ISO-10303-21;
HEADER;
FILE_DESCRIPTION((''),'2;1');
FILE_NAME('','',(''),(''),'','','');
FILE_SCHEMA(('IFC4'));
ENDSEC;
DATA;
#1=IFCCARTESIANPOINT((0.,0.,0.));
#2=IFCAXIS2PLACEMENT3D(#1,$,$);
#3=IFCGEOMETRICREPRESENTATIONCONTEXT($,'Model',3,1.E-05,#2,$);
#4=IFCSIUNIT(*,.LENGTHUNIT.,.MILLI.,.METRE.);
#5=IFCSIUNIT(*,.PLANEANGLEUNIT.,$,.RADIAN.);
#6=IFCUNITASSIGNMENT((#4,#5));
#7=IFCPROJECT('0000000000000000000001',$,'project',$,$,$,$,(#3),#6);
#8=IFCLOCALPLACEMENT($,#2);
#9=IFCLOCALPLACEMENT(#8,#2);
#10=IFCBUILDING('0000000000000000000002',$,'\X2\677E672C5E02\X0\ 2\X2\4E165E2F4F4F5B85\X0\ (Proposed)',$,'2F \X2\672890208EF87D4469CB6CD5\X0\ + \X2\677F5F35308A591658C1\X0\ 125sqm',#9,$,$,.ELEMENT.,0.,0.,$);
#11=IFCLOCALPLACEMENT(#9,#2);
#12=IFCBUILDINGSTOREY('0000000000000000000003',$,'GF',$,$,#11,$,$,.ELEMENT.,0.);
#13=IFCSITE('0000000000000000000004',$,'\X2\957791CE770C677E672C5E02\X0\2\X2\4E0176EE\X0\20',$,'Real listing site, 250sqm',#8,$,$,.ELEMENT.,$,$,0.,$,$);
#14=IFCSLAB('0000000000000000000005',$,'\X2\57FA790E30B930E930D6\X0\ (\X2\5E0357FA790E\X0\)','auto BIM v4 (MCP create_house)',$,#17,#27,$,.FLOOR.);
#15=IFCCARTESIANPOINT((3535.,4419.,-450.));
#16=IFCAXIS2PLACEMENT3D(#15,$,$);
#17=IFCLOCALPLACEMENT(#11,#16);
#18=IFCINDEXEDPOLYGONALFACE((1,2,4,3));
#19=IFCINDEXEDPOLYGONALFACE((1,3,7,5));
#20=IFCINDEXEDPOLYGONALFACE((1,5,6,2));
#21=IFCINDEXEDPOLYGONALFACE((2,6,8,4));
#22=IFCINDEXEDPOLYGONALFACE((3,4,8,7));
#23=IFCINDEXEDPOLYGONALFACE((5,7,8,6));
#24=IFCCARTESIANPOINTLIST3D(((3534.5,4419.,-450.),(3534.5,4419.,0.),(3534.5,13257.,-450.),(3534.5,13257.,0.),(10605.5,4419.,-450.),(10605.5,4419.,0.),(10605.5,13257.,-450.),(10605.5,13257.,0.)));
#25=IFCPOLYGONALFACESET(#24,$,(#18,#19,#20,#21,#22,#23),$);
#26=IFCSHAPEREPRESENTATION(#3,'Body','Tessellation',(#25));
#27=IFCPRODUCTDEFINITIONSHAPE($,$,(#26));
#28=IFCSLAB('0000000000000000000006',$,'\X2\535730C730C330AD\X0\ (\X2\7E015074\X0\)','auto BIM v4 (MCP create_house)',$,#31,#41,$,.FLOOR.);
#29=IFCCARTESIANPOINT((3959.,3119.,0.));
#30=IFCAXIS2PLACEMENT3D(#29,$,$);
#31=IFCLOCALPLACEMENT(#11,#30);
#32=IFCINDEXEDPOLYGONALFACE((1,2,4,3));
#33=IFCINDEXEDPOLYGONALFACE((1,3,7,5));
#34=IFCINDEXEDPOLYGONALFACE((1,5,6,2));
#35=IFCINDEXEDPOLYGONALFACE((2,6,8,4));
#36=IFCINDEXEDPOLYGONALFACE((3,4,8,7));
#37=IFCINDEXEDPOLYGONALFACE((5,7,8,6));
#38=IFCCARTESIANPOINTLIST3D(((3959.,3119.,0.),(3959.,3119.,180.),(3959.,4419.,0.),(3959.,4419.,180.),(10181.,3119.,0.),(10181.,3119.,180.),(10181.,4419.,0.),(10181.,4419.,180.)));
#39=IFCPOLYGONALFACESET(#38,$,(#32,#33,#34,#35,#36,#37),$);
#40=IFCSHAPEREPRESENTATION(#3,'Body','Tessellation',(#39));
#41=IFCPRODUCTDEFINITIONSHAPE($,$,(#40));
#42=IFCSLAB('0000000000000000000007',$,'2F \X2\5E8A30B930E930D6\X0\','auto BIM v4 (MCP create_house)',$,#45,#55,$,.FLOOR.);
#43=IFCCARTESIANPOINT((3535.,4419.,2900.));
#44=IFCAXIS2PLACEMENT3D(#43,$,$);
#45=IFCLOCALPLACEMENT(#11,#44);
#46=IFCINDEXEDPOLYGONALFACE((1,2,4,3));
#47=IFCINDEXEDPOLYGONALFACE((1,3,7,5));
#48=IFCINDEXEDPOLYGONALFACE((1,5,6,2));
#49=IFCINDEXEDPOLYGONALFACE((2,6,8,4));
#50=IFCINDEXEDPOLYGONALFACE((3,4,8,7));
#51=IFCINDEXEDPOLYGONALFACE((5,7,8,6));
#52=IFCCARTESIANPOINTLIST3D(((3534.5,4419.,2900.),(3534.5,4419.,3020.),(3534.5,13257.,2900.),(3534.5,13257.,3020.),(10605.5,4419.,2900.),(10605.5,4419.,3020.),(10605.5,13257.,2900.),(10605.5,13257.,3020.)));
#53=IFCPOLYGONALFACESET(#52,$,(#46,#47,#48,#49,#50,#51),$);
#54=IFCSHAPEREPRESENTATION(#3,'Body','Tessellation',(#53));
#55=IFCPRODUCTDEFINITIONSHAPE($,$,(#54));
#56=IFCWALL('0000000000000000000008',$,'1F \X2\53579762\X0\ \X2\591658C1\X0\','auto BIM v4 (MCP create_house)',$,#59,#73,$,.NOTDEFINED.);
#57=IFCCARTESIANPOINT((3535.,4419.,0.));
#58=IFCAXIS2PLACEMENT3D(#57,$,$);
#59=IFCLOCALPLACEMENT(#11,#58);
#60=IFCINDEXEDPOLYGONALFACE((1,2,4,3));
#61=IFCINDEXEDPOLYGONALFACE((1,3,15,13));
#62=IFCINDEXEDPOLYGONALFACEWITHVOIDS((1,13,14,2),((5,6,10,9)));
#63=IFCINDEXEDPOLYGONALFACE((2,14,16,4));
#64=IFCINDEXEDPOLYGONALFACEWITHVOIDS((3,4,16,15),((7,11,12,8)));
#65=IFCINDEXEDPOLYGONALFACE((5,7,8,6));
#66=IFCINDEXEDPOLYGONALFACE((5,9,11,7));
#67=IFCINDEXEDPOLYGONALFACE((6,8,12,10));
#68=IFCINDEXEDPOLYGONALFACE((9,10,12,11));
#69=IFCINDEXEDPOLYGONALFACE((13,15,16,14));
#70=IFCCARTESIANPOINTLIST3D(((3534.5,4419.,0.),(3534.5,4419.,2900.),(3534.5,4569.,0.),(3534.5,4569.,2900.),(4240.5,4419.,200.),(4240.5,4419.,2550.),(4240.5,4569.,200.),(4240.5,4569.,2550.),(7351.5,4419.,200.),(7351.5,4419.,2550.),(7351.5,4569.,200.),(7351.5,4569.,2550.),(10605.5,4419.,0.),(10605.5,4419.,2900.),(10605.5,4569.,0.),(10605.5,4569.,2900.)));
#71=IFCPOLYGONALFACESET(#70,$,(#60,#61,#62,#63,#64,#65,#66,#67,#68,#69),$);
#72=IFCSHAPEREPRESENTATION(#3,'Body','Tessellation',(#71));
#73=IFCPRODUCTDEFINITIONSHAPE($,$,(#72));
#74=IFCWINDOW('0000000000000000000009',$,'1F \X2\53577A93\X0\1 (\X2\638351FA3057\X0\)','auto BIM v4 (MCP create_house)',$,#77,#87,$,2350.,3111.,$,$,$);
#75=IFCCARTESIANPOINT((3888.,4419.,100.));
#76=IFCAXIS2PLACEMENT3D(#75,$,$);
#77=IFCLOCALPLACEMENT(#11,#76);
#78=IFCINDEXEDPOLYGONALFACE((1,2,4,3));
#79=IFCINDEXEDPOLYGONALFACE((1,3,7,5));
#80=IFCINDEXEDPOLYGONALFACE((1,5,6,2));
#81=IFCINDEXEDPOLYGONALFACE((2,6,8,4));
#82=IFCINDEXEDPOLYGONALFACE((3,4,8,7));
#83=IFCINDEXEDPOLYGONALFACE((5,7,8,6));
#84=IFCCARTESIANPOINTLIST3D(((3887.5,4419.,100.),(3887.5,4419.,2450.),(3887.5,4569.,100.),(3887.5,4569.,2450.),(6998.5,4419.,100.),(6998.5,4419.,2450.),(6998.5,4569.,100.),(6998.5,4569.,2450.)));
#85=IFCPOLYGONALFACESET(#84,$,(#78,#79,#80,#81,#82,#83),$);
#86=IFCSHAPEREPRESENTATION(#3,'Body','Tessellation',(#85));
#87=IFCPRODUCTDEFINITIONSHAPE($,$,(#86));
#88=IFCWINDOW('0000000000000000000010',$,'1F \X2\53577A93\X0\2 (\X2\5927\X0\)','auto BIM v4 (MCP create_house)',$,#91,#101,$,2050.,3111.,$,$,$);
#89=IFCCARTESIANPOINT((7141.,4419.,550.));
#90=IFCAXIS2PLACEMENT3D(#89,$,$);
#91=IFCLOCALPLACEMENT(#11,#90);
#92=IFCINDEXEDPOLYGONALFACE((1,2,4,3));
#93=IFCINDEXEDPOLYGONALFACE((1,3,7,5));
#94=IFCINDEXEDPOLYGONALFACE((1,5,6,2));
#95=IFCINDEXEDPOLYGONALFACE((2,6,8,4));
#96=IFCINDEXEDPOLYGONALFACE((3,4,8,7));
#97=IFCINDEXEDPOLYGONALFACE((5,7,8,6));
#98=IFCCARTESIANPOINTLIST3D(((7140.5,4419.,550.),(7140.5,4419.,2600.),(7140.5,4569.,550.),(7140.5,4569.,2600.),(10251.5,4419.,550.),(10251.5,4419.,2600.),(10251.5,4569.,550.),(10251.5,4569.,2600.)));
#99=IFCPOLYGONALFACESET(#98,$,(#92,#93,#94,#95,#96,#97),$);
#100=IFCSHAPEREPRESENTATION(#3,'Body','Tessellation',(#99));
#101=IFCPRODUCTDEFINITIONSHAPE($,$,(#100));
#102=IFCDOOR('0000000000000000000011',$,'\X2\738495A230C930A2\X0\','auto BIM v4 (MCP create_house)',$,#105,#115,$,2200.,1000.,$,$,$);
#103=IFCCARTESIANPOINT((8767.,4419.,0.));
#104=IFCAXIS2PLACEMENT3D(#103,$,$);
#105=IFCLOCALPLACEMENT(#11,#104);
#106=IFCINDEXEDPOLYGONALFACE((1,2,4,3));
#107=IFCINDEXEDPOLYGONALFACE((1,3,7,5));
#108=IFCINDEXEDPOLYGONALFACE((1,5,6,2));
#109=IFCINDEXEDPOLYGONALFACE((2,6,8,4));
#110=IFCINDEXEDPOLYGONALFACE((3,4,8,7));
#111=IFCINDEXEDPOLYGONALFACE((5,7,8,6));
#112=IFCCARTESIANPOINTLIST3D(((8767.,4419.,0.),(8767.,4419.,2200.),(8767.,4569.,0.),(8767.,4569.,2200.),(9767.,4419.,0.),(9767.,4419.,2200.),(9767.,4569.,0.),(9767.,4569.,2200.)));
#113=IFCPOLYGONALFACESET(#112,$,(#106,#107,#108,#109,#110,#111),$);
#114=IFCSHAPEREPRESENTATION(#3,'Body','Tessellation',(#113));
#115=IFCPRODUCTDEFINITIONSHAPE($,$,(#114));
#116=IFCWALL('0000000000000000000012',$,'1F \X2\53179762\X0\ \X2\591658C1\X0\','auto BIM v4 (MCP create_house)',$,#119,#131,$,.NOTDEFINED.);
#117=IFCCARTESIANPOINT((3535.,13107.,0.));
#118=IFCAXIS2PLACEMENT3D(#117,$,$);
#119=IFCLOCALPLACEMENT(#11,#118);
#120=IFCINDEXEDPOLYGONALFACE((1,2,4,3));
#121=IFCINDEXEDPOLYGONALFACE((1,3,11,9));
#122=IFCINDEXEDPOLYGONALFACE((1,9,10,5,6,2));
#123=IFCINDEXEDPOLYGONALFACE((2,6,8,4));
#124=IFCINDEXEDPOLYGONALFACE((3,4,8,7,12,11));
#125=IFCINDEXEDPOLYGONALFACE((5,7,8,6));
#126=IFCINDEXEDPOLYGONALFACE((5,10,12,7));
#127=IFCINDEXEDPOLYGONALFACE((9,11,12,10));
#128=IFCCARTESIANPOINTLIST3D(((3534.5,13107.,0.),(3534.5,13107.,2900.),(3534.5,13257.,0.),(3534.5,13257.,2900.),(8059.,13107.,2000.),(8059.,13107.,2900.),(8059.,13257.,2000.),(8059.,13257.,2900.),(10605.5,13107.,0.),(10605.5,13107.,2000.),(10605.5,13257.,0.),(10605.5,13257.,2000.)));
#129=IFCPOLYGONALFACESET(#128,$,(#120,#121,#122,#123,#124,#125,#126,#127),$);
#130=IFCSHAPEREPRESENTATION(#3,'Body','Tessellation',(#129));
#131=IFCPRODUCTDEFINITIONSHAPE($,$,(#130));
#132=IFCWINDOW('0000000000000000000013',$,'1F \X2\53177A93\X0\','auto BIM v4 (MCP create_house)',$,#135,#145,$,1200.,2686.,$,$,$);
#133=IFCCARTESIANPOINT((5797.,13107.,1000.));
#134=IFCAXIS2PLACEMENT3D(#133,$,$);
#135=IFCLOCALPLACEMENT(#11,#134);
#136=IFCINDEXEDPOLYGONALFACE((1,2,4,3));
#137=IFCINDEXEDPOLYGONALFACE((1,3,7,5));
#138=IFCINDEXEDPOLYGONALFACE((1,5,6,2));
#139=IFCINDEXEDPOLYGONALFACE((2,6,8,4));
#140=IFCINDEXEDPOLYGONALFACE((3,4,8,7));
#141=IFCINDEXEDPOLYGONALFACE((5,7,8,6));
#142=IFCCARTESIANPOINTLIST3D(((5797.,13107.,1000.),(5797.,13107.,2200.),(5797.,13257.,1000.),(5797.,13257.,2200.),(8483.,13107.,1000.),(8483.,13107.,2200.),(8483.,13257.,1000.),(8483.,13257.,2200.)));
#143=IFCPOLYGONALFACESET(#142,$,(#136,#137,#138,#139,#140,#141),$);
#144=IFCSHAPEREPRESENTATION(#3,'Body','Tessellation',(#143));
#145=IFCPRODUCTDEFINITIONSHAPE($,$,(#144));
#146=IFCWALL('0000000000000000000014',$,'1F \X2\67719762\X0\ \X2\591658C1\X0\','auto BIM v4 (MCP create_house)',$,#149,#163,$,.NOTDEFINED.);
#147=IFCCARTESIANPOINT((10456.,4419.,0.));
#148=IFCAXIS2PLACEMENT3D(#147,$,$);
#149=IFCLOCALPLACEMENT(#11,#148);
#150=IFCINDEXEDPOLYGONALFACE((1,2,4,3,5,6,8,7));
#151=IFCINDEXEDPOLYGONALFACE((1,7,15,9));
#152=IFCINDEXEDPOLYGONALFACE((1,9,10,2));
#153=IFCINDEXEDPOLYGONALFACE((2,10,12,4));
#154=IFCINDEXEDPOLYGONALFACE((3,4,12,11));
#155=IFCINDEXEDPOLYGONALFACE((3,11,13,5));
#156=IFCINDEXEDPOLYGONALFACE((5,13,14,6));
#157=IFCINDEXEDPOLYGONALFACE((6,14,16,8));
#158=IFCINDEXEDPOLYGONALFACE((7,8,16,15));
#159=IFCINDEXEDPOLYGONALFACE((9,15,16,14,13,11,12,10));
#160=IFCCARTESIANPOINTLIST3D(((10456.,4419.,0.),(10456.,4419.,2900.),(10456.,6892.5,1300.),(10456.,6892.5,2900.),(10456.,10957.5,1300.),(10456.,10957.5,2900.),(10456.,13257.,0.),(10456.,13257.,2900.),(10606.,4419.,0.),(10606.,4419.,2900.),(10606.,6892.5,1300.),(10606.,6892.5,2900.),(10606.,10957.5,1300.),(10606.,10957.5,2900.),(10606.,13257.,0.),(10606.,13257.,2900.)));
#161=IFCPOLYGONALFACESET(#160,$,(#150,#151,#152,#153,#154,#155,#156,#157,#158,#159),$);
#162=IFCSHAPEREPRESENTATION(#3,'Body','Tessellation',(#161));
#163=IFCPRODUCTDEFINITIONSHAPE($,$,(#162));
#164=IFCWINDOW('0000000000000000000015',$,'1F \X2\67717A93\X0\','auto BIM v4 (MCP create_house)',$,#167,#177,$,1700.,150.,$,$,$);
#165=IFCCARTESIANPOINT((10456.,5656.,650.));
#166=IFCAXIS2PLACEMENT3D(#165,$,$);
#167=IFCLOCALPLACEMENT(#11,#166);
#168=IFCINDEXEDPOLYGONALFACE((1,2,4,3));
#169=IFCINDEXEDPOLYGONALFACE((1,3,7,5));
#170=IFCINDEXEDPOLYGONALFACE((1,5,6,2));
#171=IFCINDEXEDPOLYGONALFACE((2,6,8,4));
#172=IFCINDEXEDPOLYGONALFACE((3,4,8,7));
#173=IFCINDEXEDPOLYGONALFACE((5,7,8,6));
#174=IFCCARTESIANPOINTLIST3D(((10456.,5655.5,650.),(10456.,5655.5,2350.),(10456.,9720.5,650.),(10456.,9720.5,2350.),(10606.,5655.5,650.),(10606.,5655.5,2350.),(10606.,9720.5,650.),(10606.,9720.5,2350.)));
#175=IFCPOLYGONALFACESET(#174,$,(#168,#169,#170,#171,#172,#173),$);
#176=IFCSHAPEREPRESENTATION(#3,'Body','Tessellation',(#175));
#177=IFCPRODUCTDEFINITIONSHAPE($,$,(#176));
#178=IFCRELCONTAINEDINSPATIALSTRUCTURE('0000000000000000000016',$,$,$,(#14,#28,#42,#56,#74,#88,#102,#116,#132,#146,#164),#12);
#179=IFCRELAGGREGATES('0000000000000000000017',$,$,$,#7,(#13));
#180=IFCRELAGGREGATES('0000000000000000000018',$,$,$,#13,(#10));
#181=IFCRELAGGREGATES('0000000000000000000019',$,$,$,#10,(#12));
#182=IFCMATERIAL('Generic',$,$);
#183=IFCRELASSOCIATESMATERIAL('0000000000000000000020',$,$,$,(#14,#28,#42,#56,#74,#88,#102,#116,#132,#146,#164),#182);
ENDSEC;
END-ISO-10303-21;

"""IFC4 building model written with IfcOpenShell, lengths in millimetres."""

from ifc_helpers import new_model, si_unit, frame, frame_2d, origin, place, context, project, spatial, rectangle, extrude, material, element, fill, save


model = new_model("IFC4")

# Units and contexts
model_context = context("Model", 3, precision=1e-05, world=origin())
ifc_project = project(units=[si_unit("LENGTHUNIT", "METRE", prefix="MILLI"), si_unit("PLANEANGLEUNIT", "RADIAN")], contexts=[model_context])

# Site, building, storey
site_placement = place(None, origin())
site = spatial("IfcSite", under=ifc_project, at=site_placement, Name="長野県松本市2丁目20", ObjectType="Real listing site, 250sqm", CompositionType="ELEMENT", RefElevation=0.0)
building_placement = place(site_placement, origin())
building = spatial("IfcBuilding", under=site, at=building_placement, Name="松本市 2世帯住宅 (Proposed)", ObjectType="2F 木造軸組構法 + 板張り外壁 125sqm", CompositionType="ELEMENT", ElevationOfRefHeight=0.0, ElevationOfTerrain=0.0)
storey_placement = place(building_placement, origin())
storey = spatial("IfcBuildingStorey", under=building, at=storey_placement, Name="GF", CompositionType="ELEMENT", Elevation=0.0)

# Slabs
ifc_material = material(Name="Generic")
slab_1_placement = place(storey_placement, frame((3535.0, 4419.0, -450.0)))
element("IfcSlab", 1, at=slab_1_placement, inside=storey, material=ifc_material, Name="基礎スラブ (布基礎)", Description="auto BIM v4 (MCP create_house)", PredefinedType="FLOOR", context=model_context, shape_type="SweptSolid", body=[
    extrude(rectangle(XDim=7071.0, YDim=8838.0, at=frame_2d((3535.0, 4419.0))), frame((3535.0, 4419.0, -450.0)), (0.0, 0.0, 1.0), 450.0),
])
slab_2_placement = place(storey_placement, frame((3959.0, 3119.0, 0.0)))
element("IfcSlab", 2, at=slab_2_placement, inside=storey, material=ifc_material, Name="南デッキ (縁側)", Description="auto BIM v4 (MCP create_house)", PredefinedType="FLOOR", context=model_context, shape_type="SweptSolid", body=[
    extrude(rectangle(XDim=6222.0, YDim=1300.0, at=frame_2d((3111.0, 650.0))), frame((3959.0, 3119.0, 0.0)), (0.0, 0.0, 1.0), 180.0),
])
slab_3_placement = place(storey_placement, frame((3535.0, 4419.0, 2900.0)))
element("IfcSlab", 3, at=slab_3_placement, inside=storey, material=ifc_material, Name="2F 床スラブ", Description="auto BIM v4 (MCP create_house)", PredefinedType="FLOOR", context=model_context, shape_type="SweptSolid", body=[
    extrude(rectangle(XDim=7071.0, YDim=8838.0, at=frame_2d((3535.0, 4419.0))), frame((3535.0, 4419.0, 2900.0)), (0.0, 0.0, 1.0), 120.0),
])

# Wall, openings, windows, door
wall_1_placement = place(storey_placement, frame((3535.0, 4419.0, 0.0)))
wall_1 = element("IfcWall", 4, at=wall_1_placement, inside=storey, material=ifc_material, Name="1F 南面 外壁", Description="auto BIM v4 (MCP create_house)", PredefinedType="NOTDEFINED", context=model_context, shape_type="SweptSolid", body=[
    extrude(rectangle(XDim=7071.0, YDim=150.0, at=frame_2d((3535.0, 75.0))), frame((3535.0, 4419.0, 0.0)), (0.0, 0.0, 1.0), 2900.0),
])
opening_1_placement = place(storey_placement, frame((3888.0, 4419.0, 100.0)))
opening_1 = element("IfcOpeningElement", 5, at=opening_1_placement, cuts=wall_1, PredefinedType="NOTDEFINED", context=model_context, shape_type="SweptSolid", body=[
    extrude(rectangle(XDim=3111.0, YDim=150.0, at=frame_2d((1555.0, 75.0))), frame((3888.0, 4419.0, 100.0)), (0.0, 0.0, 1.0), 2350.0),
])
opening_2_placement = place(storey_placement, frame((7141.0, 4419.0, 550.0)))
opening_2 = element("IfcOpeningElement", 6, at=opening_2_placement, cuts=wall_1, PredefinedType="NOTDEFINED", context=model_context, shape_type="SweptSolid", body=[
    extrude(rectangle(XDim=3111.0, YDim=150.0, at=frame_2d((1555.0, 75.0))), frame((7141.0, 4419.0, 550.0)), (0.0, 0.0, 1.0), 2050.0),
])
opening_3_placement = place(storey_placement, frame((8767.0, 4419.0, 0.0)))
opening_3 = element("IfcOpeningElement", 7, at=opening_3_placement, cuts=wall_1, PredefinedType="NOTDEFINED", context=model_context, shape_type="SweptSolid", body=[
    extrude(rectangle(XDim=1000.0, YDim=150.0, at=frame_2d((500.0, 75.0))), frame((8767.0, 4419.0, 0.0)), (0.0, 0.0, 1.0), 2200.0),
])
window_1_placement = place(storey_placement, frame((3888.0, 4419.0, 100.0)))
window_1 = element("IfcWindow", 8, at=window_1_placement, inside=storey, material=ifc_material, Name="1F 南窓1 (掃出し)", Description="auto BIM v4 (MCP create_house)", OverallHeight=2350.0, OverallWidth=3111.0, context=model_context, shape_type="SweptSolid", body=[
    extrude(rectangle(XDim=3111.0, YDim=150.0, at=frame_2d((1555.0, 75.0))), frame((3888.0, 4419.0, 100.0)), (0.0, 0.0, 1.0), 2350.0),
])
fill(opening_1, window_1)
window_2_placement = place(storey_placement, frame((7141.0, 4419.0, 550.0)))
window_2 = element("IfcWindow", 9, at=window_2_placement, inside=storey, material=ifc_material, Name="1F 南窓2 (大)", Description="auto BIM v4 (MCP create_house)", OverallHeight=2050.0, OverallWidth=3111.0, context=model_context, shape_type="SweptSolid", body=[
    extrude(rectangle(XDim=3111.0, YDim=150.0, at=frame_2d((1555.0, 75.0))), frame((7141.0, 4419.0, 550.0)), (0.0, 0.0, 1.0), 2050.0),
])
fill(opening_2, window_2)
door_1_placement = place(storey_placement, frame((8767.0, 4419.0, 0.0)))
door_1 = element("IfcDoor", 10, at=door_1_placement, inside=storey, material=ifc_material, Name="玄関ドア", Description="auto BIM v4 (MCP create_house)", OverallHeight=2200.0, OverallWidth=1000.0, context=model_context, shape_type="SweptSolid", body=[
    extrude(rectangle(XDim=1000.0, YDim=150.0, at=frame_2d((500.0, 75.0))), frame((8767.0, 4419.0, 0.0)), (0.0, 0.0, 1.0), 2200.0),
])
fill(opening_3, door_1)

# Walls, openings, windows
wall_2_placement = place(storey_placement, frame((3535.0, 13107.0, 0.0)))
wall_2 = element("IfcWall", 11, at=wall_2_placement, inside=storey, material=ifc_material, Name="1F 北面 外壁", Description="auto BIM v4 (MCP create_house)", PredefinedType="NOTDEFINED", context=model_context, shape_type="SweptSolid", body=[
    extrude(rectangle(XDim=7071.0, YDim=150.0, at=frame_2d((3535.0, 75.0))), frame((3535.0, 13107.0, 0.0)), (0.0, 0.0, 1.0), 2900.0),
])
opening_4_placement = place(storey_placement, frame((5797.0, 13107.0, 1000.0)))
opening_4 = element("IfcOpeningElement", 12, at=opening_4_placement, cuts=wall_2, PredefinedType="NOTDEFINED", context=model_context, shape_type="SweptSolid", body=[
    extrude(rectangle(XDim=2686.0, YDim=150.0, at=frame_2d((1343.0, 75.0))), frame((5797.0, 13107.0, 1000.0)), (0.0, 0.0, 1.0), 1200.0),
])
window_3_placement = place(storey_placement, frame((5797.0, 13107.0, 1000.0)))
window_3 = element("IfcWindow", 13, at=window_3_placement, inside=storey, material=ifc_material, Name="1F 北窓", Description="auto BIM v4 (MCP create_house)", OverallHeight=1200.0, OverallWidth=2686.0, context=model_context, shape_type="SweptSolid", body=[
    extrude(rectangle(XDim=2686.0, YDim=150.0, at=frame_2d((1343.0, 75.0))), frame((5797.0, 13107.0, 1000.0)), (0.0, 0.0, 1.0), 1200.0),
])
fill(opening_4, window_3)
wall_3_placement = place(storey_placement, frame((10456.0, 4419.0, 0.0)))
wall_3 = element("IfcWall", 14, at=wall_3_placement, inside=storey, material=ifc_material, Name="1F 東面 外壁", Description="auto BIM v4 (MCP create_house)", PredefinedType="NOTDEFINED", context=model_context, shape_type="SweptSolid", body=[
    extrude(rectangle(XDim=150.0, YDim=8838.0, at=frame_2d((75.0, 4419.0))), frame((10456.0, 4419.0, 0.0)), (0.0, 0.0, 1.0), 2900.0),
])
opening_5_placement = place(storey_placement, frame((10456.0, 5656.0, 650.0)))
opening_5 = element("IfcOpeningElement", 15, at=opening_5_placement, cuts=wall_3, PredefinedType="NOTDEFINED", context=model_context, shape_type="SweptSolid", body=[
    extrude(rectangle(XDim=150.0, YDim=4065.0, at=frame_2d((75.0, 2032.0))), frame((10456.0, 5656.0, 650.0)), (0.0, 0.0, 1.0), 1700.0),
])
window_4_placement = place(storey_placement, frame((10456.0, 5656.0, 650.0)))
window_4 = element("IfcWindow", 16, at=window_4_placement, inside=storey, material=ifc_material, Name="1F 東窓", Description="auto BIM v4 (MCP create_house)", OverallHeight=1700.0, OverallWidth=150.0, context=model_context, shape_type="SweptSolid", body=[
    extrude(rectangle(XDim=150.0, YDim=4065.0, at=frame_2d((75.0, 2032.0))), frame((10456.0, 5656.0, 650.0)), (0.0, 0.0, 1.0), 1700.0),
])
fill(opening_5, window_4)

save(model, "model.ifc")
